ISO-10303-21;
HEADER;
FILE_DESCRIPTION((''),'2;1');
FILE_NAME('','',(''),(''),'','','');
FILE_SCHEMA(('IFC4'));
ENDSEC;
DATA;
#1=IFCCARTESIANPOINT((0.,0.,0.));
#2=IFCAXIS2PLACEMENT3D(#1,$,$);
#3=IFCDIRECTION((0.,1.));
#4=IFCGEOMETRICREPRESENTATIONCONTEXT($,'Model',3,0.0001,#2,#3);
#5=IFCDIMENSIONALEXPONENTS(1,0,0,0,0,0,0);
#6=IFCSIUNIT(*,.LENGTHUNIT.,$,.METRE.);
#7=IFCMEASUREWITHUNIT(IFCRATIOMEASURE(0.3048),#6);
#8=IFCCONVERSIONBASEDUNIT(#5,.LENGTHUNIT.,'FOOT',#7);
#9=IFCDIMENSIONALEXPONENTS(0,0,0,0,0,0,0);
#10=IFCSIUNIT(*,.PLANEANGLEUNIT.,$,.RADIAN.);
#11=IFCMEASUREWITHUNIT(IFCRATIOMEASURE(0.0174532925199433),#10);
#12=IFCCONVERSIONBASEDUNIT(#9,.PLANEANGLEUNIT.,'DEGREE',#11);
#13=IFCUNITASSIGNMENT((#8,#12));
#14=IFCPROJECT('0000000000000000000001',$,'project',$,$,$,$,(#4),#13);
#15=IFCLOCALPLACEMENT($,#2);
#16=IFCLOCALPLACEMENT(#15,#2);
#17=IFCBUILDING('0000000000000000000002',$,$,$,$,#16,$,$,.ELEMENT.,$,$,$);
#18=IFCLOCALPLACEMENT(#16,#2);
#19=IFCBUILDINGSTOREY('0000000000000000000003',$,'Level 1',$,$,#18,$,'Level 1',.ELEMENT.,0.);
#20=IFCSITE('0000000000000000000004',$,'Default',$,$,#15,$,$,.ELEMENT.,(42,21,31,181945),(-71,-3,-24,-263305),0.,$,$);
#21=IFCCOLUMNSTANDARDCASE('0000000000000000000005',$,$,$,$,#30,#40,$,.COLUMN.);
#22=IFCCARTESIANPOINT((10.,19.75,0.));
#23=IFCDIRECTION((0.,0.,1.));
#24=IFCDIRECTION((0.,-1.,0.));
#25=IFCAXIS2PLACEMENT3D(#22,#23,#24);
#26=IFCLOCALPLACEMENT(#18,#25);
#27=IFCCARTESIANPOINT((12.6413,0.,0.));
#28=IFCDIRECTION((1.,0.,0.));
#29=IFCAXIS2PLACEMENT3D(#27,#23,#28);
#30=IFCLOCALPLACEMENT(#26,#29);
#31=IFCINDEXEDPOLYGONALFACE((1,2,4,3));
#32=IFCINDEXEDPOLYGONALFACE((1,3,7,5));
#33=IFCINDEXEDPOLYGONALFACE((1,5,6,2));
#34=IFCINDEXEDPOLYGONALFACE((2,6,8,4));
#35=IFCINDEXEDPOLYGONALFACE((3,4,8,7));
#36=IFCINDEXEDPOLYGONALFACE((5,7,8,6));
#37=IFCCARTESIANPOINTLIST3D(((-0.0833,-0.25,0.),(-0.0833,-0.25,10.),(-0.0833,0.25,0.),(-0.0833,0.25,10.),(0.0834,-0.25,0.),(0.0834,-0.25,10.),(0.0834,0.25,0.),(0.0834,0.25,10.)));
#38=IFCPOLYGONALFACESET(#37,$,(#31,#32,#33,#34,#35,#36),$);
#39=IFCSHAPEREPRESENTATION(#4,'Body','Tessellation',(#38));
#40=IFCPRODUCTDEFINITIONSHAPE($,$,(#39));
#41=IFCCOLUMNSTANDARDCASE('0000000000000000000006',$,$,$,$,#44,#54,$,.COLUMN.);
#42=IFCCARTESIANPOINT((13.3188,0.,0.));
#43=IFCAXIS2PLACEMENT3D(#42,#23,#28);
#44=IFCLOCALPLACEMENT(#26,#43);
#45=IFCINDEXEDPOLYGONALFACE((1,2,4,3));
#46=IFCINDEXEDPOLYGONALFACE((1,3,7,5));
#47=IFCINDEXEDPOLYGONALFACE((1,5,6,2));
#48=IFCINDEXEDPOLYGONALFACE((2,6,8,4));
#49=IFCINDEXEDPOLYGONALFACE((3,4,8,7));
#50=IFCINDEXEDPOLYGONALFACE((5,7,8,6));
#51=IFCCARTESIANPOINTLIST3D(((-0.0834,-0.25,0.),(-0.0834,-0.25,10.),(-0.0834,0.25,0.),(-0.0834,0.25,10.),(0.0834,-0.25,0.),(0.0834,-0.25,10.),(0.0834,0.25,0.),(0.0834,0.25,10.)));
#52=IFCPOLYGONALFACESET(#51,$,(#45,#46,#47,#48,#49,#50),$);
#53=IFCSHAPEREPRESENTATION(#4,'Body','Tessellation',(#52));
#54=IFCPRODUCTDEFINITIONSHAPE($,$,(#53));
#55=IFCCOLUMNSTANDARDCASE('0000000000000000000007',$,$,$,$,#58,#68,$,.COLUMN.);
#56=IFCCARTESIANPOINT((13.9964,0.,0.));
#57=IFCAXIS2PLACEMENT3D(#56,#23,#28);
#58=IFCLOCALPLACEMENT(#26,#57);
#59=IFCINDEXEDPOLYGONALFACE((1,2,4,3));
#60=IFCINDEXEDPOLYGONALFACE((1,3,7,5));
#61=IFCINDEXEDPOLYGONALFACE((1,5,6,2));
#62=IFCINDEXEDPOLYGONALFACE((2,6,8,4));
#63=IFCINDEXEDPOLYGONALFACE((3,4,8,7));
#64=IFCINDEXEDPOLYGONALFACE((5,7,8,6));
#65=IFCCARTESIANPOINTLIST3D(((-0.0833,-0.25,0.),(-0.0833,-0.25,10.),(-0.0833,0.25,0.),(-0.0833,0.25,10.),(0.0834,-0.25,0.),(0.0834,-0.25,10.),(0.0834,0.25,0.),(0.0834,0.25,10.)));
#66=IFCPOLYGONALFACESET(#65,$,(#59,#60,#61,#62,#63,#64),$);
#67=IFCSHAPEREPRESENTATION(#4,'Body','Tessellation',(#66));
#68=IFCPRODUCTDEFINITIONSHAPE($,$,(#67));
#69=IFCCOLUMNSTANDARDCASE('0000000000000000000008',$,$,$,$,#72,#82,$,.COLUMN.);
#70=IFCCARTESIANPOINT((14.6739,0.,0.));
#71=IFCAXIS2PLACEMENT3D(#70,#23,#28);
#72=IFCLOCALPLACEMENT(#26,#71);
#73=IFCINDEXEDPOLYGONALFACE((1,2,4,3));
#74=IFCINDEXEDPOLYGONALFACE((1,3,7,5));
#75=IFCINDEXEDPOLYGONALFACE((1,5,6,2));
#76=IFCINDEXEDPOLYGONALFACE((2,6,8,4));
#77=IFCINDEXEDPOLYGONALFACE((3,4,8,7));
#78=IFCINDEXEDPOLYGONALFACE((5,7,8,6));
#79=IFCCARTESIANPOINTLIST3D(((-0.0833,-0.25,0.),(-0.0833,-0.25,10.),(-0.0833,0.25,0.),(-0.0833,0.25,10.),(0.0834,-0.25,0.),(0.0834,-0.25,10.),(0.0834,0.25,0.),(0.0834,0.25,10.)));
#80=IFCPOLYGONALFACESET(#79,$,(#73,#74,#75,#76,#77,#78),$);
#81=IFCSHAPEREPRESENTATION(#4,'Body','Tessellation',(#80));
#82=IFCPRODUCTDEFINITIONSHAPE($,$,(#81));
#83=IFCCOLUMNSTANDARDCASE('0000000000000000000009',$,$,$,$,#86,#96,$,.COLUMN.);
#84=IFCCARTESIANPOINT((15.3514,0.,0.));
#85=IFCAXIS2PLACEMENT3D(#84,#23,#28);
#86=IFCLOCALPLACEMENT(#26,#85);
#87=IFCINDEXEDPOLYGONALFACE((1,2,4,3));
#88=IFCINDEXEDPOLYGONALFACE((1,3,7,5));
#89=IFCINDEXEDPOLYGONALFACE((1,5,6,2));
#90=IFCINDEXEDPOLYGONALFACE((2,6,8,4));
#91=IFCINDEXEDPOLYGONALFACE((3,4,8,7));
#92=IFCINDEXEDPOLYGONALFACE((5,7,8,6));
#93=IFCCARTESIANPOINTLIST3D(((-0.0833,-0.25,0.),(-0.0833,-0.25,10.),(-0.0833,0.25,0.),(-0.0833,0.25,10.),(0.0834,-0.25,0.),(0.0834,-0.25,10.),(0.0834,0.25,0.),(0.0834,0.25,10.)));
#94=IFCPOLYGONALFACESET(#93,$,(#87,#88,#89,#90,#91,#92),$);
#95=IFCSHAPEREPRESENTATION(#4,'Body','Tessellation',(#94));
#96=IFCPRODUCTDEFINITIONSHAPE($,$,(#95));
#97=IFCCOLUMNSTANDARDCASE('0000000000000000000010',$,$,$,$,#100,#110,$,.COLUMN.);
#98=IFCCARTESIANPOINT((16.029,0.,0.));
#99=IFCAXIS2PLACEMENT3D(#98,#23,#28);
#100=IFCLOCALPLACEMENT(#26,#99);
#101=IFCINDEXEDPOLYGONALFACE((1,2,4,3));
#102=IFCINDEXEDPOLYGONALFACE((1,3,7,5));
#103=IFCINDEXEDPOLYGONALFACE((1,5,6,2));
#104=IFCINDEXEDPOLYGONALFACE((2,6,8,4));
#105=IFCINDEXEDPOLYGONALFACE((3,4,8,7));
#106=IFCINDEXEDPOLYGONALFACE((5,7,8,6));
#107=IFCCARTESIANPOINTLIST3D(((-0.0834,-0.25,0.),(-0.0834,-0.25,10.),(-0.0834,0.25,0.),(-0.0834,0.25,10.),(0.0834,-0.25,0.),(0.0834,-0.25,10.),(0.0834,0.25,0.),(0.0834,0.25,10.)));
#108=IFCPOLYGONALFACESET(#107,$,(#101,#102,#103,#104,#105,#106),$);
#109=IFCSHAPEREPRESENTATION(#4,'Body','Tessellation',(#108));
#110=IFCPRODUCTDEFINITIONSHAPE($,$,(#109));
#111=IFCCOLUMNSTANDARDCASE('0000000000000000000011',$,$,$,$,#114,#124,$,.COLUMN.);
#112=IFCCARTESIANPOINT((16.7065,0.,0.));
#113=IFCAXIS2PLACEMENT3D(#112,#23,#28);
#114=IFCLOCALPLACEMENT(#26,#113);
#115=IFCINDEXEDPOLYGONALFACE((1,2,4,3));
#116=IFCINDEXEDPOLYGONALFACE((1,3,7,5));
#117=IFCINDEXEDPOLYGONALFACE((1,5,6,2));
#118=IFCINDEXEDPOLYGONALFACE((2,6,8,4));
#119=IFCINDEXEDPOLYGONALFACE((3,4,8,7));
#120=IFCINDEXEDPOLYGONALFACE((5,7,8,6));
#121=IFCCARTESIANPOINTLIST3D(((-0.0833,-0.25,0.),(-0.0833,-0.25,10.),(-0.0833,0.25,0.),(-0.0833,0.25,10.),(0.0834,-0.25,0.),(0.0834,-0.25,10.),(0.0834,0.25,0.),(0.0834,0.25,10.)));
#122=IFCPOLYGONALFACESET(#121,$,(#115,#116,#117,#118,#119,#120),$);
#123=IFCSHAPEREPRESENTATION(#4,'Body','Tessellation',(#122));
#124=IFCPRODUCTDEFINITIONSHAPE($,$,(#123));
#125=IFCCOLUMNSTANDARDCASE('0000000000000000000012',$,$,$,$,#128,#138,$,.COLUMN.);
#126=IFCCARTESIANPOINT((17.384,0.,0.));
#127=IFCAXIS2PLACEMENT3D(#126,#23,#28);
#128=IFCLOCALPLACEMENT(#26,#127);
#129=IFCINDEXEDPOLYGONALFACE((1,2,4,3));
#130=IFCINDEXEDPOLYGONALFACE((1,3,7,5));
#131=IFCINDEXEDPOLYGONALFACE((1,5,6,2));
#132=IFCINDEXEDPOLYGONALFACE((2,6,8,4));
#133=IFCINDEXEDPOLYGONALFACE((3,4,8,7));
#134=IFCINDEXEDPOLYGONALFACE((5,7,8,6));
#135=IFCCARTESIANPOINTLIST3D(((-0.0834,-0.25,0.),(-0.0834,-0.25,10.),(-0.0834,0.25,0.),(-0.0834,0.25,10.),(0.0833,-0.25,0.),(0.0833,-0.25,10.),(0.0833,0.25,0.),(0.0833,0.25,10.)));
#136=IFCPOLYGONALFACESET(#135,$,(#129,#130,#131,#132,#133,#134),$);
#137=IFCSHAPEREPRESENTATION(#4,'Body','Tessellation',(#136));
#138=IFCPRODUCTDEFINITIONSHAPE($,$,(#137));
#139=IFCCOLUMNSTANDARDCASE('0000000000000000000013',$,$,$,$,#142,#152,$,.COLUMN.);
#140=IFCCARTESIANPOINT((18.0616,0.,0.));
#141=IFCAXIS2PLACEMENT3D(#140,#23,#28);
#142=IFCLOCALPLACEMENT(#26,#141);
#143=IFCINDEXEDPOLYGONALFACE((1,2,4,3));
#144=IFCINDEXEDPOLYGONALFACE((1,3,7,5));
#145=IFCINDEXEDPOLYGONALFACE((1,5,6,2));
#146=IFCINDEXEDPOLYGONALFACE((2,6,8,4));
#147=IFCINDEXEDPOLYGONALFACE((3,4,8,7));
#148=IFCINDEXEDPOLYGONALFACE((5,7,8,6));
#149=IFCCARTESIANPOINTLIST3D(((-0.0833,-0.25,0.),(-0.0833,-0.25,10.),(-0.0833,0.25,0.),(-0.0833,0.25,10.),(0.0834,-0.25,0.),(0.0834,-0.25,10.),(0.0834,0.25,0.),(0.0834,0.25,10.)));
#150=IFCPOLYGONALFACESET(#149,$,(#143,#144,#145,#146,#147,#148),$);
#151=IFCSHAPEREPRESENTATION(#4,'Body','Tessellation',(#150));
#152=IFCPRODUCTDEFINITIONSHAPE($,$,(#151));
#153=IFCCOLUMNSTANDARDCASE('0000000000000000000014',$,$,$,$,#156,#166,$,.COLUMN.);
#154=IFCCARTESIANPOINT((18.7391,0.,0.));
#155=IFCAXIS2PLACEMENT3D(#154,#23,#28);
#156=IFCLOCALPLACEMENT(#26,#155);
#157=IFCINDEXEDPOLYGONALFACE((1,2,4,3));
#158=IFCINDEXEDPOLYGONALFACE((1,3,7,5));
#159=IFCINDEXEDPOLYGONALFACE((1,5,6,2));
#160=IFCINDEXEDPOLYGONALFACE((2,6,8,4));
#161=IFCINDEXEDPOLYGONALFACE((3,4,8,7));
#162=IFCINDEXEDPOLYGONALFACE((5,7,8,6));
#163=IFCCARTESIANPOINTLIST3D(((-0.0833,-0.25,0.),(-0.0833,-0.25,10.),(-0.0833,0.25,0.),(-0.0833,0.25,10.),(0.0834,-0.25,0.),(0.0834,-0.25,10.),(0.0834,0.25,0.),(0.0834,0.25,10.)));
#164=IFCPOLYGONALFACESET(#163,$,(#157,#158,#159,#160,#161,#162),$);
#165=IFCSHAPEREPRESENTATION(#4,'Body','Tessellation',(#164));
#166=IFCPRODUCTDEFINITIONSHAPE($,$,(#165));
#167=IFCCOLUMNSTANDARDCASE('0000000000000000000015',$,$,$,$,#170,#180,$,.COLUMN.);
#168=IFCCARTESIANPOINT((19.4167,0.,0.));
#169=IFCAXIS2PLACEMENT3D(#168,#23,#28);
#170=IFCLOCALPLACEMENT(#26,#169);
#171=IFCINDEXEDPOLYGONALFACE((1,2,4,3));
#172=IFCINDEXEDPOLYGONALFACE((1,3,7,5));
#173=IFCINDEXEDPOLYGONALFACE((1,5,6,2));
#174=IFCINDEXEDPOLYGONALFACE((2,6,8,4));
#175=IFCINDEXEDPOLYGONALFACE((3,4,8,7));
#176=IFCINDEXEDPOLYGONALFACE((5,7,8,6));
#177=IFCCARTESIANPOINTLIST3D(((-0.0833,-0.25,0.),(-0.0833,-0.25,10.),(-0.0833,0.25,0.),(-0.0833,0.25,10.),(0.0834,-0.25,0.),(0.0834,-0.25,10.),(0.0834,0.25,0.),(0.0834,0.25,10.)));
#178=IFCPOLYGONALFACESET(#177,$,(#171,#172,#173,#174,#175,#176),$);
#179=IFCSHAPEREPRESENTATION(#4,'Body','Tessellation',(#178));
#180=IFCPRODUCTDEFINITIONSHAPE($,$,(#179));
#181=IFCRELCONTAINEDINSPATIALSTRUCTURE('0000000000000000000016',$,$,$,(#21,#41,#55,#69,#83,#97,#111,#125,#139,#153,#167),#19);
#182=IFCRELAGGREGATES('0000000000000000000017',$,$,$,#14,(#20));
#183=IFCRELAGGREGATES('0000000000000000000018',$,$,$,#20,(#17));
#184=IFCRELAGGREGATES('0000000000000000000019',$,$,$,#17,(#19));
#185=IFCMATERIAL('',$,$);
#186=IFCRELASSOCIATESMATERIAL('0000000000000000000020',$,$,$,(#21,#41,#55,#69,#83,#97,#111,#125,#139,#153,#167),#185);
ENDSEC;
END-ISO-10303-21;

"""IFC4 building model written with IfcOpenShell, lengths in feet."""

from ifc_helpers import new_model, entity, si_unit, converted_unit, direction, frame, origin, place, context, project, spatial, rectangle, extrude, material, element, save


model = new_model("IFC4")

# Units and contexts
model_context = context("Model", 3, precision=0.0001, world=origin(), true_north=direction((0.0, 1.0)))
ifc_project = project(units=[converted_unit("LENGTHUNIT", "FOOT", entity("IfcRatioMeasure", 0.3048), si_unit("LENGTHUNIT", "METRE"), dimensions=[1, 0, 0, 0, 0, 0, 0]), converted_unit("PLANEANGLEUNIT", "DEGREE", entity("IfcRatioMeasure", 0.0174532925199433), si_unit("PLANEANGLEUNIT", "RADIAN"), dimensions=[0, 0, 0, 0, 0, 0, 0])], contexts=[model_context])

# Site, building, storey
site_placement = place(None, origin())
site = spatial("IfcSite", under=ifc_project, at=site_placement, Name="Default", CompositionType="ELEMENT", RefLatitude=(42, 21, 31, 181945), RefLongitude=(-71, -3, -24, -263305), RefElevation=0.0)
building_placement = place(site_placement, origin())
building = spatial("IfcBuilding", under=site, at=building_placement, CompositionType="ELEMENT")
storey_placement = place(building_placement, origin())
storey = spatial("IfcBuildingStorey", under=building, at=storey_placement, Name="Level 1", LongName="Level 1", CompositionType="ELEMENT", Elevation=0.0)

# Columns
ifc_material_1 = material(Name="")
placement_1 = place(storey_placement, frame((10.0, 19.75, 0.0), z_axis=(0.0, 0.0, 1.0), x_axis=(0.0, -1.0, 0.0)))
for number, where, z_axis, x_axis in (
    (1, (12.6413, 0.0, 0.0), (0.0, 0.0, 1.0), (1.0, 0.0, 0.0)),
    (2, (13.3188, 0.0, 0.0), (0.0, 0.0, 1.0), (1.0, 0.0, 0.0)),
    (3, (13.9964, 0.0, 0.0), (0.0, 0.0, 1.0), (1.0, 0.0, 0.0)),
    (4, (14.6739, 0.0, 0.0), (0.0, 0.0, 1.0), (1.0, 0.0, 0.0)),
    (5, (15.3514, 0.0, 0.0), (0.0, 0.0, 1.0), (1.0, 0.0, 0.0)),
    (6, (16.029, 0.0, 0.0), (0.0, 0.0, 1.0), (1.0, 0.0, 0.0)),
    (7, (16.7065, 0.0, 0.0), (0.0, 0.0, 1.0), (1.0, 0.0, 0.0)),
    (8, (17.384, 0.0, 0.0), (0.0, 0.0, 1.0), (1.0, 0.0, 0.0)),
    (9, (18.0616, 0.0, 0.0), (0.0, 0.0, 1.0), (1.0, 0.0, 0.0)),
    (10, (18.7391, 0.0, 0.0), (0.0, 0.0, 1.0), (1.0, 0.0, 0.0)),
    (11, (19.4167, 0.0, 0.0), (0.0, 0.0, 1.0), (1.0, 0.0, 0.0)),
):
    element("IfcColumnStandardCase", number, at=place(placement_1, frame(where, z_axis=z_axis, x_axis=x_axis)), inside=storey, material=ifc_material_1, PredefinedType="COLUMN", context=model_context, shape_type="SweptSolid", body=[
        extrude(rectangle(XDim=0.1667, YDim=0.5), origin(), (0.0, 0.0, 1.0), 10.0),
    ])

save(model, "model.ifc")
